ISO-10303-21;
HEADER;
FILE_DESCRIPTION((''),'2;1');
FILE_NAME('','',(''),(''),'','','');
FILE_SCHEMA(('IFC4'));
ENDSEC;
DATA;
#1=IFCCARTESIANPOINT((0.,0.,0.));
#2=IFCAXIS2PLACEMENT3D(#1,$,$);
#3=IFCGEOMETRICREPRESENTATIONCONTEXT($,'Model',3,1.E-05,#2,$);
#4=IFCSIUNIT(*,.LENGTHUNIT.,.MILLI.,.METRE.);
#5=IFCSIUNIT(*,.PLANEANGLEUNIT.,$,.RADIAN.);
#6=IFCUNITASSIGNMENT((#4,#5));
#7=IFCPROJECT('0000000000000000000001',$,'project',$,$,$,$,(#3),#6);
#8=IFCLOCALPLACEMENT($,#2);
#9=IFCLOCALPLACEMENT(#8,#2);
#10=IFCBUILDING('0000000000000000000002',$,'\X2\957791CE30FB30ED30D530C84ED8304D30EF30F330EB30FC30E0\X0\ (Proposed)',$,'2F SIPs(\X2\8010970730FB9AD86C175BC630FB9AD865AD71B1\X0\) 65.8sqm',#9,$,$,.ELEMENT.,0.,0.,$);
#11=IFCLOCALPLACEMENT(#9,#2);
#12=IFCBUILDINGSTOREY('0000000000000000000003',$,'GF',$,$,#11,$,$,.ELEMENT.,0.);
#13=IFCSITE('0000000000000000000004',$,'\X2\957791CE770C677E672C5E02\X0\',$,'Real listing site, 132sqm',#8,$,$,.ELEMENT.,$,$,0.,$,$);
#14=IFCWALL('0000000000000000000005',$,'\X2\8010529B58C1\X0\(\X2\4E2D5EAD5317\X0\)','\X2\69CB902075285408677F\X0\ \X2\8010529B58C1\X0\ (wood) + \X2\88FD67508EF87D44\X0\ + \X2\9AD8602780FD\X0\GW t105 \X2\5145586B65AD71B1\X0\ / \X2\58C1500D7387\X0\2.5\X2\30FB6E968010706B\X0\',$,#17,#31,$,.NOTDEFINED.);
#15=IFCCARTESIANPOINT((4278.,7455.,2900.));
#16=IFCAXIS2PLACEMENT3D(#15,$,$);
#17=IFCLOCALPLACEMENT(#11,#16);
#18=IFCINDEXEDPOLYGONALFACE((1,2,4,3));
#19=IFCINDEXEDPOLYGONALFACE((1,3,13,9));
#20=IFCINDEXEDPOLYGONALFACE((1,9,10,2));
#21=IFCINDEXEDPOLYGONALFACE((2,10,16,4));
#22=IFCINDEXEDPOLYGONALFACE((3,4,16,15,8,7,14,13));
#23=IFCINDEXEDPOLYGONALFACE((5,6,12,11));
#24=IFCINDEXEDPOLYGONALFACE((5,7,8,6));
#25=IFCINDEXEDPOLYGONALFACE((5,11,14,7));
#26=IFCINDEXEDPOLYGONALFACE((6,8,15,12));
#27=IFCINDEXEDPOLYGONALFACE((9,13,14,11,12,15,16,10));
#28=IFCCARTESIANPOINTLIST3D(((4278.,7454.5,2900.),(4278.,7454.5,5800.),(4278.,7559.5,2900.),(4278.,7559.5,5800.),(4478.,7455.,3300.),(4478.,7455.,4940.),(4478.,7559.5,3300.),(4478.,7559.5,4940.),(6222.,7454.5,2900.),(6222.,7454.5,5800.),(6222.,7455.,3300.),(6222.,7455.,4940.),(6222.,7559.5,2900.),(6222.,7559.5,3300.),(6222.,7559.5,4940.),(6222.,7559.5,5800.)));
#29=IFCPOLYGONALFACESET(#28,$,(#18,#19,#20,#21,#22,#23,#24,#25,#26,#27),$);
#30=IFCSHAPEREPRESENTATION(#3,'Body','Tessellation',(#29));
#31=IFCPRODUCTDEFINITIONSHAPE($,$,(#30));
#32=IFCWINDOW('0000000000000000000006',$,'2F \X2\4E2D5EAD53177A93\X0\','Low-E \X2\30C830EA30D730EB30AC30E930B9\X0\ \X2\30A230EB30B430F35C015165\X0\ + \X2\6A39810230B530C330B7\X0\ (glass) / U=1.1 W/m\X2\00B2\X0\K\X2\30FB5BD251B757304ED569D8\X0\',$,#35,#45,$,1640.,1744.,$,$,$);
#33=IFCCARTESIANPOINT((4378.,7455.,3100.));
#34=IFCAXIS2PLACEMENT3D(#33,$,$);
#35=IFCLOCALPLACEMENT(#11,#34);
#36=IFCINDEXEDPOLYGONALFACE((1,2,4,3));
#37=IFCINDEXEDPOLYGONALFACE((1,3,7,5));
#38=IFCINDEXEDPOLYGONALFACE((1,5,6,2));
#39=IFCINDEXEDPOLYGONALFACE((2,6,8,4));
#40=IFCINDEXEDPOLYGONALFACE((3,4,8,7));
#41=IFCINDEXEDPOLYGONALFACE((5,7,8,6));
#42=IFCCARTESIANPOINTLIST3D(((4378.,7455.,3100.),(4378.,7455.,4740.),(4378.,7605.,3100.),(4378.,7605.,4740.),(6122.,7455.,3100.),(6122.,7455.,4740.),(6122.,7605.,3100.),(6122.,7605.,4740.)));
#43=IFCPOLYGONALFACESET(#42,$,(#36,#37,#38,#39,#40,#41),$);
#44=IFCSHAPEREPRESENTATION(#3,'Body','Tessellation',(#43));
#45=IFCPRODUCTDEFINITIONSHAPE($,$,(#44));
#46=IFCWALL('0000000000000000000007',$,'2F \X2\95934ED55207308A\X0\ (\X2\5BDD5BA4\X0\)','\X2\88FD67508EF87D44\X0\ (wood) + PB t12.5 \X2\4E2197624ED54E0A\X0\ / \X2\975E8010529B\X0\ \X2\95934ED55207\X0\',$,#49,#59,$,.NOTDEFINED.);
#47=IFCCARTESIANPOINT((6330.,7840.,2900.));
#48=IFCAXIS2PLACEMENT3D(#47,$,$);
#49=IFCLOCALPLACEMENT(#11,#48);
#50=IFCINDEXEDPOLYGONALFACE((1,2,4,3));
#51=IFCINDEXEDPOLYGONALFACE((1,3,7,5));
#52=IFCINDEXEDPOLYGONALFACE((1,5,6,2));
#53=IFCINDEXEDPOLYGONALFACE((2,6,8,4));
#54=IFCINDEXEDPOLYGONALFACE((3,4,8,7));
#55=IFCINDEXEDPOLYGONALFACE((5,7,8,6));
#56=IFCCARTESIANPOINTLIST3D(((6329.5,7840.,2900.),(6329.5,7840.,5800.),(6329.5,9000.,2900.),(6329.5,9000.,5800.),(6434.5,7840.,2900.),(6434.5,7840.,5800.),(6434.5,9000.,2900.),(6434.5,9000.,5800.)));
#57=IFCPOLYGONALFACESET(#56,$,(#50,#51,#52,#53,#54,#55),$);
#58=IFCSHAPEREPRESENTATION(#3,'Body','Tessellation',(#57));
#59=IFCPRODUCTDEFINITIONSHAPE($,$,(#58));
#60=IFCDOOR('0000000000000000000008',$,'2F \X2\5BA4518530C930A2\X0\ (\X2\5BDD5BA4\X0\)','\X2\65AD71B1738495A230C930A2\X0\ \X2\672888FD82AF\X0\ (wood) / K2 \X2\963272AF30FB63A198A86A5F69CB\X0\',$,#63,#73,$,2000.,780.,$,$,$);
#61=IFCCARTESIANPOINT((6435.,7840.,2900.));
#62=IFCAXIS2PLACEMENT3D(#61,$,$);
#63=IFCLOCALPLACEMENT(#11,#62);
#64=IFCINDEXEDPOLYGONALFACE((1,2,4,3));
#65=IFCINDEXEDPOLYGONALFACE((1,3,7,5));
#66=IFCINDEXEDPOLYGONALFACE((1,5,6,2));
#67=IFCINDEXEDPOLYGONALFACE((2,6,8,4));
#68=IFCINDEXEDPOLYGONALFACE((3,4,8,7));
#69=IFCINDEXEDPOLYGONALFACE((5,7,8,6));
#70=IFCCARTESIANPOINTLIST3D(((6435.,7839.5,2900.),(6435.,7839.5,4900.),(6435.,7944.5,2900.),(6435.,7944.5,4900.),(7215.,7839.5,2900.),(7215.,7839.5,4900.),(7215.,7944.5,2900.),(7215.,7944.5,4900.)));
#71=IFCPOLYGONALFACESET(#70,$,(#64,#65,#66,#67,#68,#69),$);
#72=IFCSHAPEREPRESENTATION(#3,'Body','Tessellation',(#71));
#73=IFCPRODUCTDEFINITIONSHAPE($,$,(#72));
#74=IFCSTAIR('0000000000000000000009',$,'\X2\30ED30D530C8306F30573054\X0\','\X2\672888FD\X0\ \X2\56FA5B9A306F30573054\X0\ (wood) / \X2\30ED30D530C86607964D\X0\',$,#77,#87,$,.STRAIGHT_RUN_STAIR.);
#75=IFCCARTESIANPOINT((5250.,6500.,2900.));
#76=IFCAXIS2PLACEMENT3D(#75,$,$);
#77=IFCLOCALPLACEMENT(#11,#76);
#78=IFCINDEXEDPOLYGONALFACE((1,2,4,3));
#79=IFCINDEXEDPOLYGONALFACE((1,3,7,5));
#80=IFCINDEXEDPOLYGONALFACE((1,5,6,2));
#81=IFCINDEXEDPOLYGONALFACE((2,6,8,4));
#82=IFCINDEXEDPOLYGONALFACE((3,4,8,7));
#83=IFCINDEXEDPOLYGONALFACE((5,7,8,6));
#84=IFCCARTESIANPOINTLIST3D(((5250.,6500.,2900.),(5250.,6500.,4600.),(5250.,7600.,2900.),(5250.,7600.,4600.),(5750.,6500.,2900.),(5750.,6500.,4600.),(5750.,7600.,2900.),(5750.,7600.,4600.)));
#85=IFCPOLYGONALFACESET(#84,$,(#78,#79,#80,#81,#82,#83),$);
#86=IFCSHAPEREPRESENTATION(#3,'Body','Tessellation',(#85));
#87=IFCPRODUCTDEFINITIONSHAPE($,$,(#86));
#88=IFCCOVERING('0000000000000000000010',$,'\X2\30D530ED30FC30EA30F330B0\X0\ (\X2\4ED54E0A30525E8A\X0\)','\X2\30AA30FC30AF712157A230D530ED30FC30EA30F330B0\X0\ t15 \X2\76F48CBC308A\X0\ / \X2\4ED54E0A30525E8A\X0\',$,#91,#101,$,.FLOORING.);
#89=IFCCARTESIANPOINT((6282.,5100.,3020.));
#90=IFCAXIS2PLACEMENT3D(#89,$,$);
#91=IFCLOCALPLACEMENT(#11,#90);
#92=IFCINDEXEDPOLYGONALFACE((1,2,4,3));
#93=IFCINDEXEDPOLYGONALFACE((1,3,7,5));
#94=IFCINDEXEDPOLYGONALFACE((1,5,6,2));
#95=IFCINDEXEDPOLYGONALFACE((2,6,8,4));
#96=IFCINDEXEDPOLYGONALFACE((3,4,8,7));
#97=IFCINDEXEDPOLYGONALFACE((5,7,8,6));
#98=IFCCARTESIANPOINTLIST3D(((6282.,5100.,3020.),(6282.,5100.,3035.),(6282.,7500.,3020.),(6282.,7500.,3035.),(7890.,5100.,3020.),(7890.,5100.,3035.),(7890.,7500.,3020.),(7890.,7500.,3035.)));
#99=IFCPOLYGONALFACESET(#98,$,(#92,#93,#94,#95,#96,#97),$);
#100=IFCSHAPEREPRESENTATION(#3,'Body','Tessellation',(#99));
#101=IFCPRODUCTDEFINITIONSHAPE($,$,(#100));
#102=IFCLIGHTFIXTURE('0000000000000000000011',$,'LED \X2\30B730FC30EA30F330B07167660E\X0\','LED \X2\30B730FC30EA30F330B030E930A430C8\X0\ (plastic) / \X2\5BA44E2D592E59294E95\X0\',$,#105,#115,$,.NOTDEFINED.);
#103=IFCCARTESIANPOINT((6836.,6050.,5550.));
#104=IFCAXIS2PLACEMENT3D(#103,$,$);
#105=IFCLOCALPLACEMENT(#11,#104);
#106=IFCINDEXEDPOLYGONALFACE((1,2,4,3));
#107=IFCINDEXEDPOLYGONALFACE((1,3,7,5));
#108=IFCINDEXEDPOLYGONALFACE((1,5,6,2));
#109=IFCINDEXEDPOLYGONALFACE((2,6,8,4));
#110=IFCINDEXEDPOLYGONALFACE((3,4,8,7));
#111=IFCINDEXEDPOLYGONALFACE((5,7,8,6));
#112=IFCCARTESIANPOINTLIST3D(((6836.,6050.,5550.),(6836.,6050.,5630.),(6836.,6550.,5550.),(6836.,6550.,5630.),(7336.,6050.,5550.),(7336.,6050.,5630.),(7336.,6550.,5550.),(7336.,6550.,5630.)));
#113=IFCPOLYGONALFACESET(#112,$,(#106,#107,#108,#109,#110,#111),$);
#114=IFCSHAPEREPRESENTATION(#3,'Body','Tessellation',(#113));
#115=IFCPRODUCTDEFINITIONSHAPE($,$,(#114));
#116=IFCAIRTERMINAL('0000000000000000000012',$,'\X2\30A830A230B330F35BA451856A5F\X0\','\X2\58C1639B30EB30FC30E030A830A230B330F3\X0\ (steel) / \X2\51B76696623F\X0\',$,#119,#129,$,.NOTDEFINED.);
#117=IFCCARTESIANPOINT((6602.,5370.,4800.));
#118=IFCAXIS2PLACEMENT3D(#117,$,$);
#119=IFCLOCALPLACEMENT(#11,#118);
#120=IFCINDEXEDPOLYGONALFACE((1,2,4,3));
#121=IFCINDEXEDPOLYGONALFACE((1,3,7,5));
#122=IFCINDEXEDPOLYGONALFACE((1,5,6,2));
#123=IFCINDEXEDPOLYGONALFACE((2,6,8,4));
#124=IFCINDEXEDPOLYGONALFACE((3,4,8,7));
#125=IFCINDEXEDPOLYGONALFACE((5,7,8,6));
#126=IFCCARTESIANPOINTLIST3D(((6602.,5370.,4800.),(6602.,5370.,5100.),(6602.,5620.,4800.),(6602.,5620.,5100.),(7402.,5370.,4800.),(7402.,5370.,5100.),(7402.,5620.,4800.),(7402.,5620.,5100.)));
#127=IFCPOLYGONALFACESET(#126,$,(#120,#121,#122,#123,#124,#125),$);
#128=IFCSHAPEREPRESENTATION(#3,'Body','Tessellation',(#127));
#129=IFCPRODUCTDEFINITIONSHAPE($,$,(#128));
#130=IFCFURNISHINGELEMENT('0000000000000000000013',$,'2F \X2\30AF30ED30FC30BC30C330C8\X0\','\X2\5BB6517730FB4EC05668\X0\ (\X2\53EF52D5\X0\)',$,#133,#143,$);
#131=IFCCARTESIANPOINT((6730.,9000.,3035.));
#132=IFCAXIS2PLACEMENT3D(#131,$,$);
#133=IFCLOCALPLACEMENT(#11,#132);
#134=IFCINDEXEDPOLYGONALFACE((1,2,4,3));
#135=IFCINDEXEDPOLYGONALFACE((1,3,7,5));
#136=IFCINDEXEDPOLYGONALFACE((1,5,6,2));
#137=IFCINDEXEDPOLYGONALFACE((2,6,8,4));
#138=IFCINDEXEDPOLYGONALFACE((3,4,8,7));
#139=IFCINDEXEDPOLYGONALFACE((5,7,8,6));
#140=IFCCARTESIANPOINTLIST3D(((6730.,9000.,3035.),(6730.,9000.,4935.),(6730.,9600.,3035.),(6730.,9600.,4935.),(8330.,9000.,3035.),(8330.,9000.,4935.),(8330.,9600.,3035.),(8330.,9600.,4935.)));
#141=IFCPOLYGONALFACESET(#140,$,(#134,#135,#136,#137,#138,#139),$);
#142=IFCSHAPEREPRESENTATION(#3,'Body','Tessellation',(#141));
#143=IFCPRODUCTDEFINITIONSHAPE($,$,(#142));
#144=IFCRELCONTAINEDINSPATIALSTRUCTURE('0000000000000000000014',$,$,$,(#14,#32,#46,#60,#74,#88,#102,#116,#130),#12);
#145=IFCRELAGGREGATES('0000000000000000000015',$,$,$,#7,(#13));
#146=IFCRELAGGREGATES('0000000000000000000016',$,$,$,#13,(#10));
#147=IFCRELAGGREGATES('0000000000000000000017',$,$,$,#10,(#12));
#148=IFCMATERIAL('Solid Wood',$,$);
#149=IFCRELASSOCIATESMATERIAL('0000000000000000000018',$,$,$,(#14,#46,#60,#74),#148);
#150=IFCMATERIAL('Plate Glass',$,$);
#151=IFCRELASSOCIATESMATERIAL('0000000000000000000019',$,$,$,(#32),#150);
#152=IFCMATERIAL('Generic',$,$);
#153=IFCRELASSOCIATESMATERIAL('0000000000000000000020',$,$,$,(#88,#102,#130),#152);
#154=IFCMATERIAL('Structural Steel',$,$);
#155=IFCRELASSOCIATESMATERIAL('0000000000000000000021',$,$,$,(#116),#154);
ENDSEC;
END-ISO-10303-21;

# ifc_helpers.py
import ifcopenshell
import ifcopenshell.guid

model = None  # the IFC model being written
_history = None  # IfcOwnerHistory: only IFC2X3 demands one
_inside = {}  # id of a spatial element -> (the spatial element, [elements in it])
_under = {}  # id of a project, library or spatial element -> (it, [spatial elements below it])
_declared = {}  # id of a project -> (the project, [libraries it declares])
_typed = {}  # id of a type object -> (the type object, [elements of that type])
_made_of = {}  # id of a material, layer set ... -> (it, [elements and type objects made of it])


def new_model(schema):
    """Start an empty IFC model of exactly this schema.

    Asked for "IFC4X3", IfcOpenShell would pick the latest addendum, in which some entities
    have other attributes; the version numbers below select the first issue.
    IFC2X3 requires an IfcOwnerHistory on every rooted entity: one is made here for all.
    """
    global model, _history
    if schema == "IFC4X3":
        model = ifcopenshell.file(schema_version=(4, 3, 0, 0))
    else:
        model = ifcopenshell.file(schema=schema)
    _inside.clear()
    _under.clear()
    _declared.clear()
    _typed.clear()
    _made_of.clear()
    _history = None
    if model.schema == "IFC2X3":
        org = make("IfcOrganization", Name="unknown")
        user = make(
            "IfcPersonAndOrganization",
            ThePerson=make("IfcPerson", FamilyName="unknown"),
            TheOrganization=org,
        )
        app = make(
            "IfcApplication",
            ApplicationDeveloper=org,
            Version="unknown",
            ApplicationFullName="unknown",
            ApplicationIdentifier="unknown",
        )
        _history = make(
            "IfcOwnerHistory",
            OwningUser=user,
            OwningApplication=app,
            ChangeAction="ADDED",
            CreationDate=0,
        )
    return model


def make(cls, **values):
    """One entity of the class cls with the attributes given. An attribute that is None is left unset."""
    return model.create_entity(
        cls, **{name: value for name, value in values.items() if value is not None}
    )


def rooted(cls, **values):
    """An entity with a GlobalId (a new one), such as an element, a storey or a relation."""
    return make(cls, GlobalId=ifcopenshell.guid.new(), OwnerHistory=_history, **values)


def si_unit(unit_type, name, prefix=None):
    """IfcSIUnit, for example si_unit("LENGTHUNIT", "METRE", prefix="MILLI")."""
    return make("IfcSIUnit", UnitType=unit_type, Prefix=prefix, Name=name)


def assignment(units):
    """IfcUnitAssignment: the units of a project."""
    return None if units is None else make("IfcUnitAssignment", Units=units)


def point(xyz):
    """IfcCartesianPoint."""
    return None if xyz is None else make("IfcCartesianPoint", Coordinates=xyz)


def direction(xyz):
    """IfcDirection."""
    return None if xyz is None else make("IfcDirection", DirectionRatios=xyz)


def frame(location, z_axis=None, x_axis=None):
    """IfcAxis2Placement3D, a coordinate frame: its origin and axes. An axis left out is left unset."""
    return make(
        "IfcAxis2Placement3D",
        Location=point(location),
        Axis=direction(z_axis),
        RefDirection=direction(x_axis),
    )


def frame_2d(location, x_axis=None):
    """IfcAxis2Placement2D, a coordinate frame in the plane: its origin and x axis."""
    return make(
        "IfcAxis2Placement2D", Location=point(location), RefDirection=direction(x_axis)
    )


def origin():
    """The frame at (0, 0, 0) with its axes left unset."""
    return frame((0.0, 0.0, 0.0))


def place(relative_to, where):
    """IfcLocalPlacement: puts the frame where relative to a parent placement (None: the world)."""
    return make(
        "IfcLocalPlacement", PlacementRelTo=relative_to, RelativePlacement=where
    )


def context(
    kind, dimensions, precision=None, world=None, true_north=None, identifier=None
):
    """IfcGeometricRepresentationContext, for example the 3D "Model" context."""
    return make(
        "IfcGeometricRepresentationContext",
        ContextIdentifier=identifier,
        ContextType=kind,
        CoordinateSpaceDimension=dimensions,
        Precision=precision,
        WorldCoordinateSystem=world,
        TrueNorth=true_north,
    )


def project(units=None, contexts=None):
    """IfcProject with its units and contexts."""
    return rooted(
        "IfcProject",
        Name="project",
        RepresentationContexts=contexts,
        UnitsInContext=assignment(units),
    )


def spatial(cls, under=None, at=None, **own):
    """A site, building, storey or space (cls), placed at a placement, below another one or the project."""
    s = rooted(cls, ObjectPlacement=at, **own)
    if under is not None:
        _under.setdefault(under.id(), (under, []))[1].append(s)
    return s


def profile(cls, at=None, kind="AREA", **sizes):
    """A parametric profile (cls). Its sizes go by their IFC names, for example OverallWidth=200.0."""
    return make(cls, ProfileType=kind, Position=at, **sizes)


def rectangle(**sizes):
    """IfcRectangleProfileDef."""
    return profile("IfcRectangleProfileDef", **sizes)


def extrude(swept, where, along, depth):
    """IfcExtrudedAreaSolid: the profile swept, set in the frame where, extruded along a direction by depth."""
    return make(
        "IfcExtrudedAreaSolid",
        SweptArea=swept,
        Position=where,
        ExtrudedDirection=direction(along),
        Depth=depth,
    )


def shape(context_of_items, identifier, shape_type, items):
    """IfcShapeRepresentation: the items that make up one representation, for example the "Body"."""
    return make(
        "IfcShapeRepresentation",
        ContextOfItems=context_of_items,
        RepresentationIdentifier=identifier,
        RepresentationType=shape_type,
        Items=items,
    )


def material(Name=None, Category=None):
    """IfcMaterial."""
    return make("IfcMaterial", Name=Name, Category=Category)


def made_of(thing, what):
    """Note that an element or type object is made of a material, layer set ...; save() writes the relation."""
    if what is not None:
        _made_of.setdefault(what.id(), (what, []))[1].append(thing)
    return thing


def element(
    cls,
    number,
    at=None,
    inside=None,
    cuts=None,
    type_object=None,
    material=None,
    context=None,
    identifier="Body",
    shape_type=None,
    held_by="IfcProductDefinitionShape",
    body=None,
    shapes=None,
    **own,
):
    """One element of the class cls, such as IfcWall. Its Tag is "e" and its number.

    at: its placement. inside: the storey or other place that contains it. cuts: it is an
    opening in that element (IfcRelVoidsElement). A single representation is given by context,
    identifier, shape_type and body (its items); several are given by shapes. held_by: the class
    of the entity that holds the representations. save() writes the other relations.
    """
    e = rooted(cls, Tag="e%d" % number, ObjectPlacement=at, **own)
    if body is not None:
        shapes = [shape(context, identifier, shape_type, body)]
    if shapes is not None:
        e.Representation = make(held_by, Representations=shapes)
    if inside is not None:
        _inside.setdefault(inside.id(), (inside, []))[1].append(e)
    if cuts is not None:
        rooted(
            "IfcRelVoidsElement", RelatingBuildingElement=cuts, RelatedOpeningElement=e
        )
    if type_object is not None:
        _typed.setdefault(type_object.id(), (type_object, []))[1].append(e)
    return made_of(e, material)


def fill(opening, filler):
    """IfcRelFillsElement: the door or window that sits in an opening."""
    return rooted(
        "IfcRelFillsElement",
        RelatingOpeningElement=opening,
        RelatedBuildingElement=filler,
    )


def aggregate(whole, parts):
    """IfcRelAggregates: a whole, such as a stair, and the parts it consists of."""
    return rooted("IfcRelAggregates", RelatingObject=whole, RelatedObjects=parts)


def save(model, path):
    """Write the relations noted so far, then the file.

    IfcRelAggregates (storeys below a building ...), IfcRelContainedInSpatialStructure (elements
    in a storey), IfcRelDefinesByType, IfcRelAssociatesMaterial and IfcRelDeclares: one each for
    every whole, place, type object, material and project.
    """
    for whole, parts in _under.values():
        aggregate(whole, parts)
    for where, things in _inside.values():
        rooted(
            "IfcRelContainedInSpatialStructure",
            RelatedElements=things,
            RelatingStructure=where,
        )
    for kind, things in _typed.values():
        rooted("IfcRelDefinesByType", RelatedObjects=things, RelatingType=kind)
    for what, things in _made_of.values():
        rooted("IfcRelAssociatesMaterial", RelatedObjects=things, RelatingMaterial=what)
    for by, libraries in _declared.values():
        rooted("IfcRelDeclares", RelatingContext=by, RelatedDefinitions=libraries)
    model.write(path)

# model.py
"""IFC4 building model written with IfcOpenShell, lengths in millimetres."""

from ifc_helpers import new_model, si_unit, frame, frame_2d, origin, place, context, project, spatial, rectangle, extrude, material, element, fill, save


model = new_model("IFC4")

# Units and contexts
model_context = context("Model", 3, precision=1e-05, world=origin())
ifc_project = project(units=[si_unit("LENGTHUNIT", "METRE", prefix="MILLI"), si_unit("PLANEANGLEUNIT", "RADIAN")], contexts=[model_context])

# Site, building, storey
site_placement = place(None, origin())
site = spatial("IfcSite", under=ifc_project, at=site_placement, Name="長野県松本市", ObjectType="Real listing site, 132sqm", CompositionType="ELEMENT", RefElevation=0.0)
building_placement = place(site_placement, origin())
building = spatial("IfcBuilding", under=site, at=building_placement, Name="長野・ロフト付きワンルーム (Proposed)", ObjectType="2F SIPs(耐震・高気密・高断熱) 65.8sqm", CompositionType="ELEMENT", ElevationOfRefHeight=0.0, ElevationOfTerrain=0.0)
storey_placement = place(building_placement, origin())
storey = spatial("IfcBuildingStorey", under=building, at=storey_placement, Name="GF", CompositionType="ELEMENT", Elevation=0.0)

# Shared definitions
ifc_material_1 = material(Name="Solid Wood")

# Wall, opening, window
wall_1_placement = place(storey_placement, frame((4278.0, 7455.0, 2900.0)))
wall_1 = element("IfcWall", 1, at=wall_1_placement, inside=storey, material=ifc_material_1, Name="耐力壁(中庭北)", Description="構造用合板 耐力壁 (wood) + 製材軸組 + 高性能GW t105 充填断熱 / 壁倍率2.5・準耐火", PredefinedType="NOTDEFINED", context=model_context, shape_type="SweptSolid", body=[
    extrude(rectangle(XDim=1944.0, YDim=105.0, at=frame_2d((972.0, 52.0))), frame((4278.0, 7455.0, 2900.0)), (0.0, 0.0, 1.0), 2900.0),
])
opening_placement = place(storey_placement, frame((4378.0, 7455.0, 3100.0)))
opening = element("IfcOpeningElement", 2, at=opening_placement, cuts=wall_1, PredefinedType="NOTDEFINED", context=model_context, shape_type="SweptSolid", body=[
    extrude(rectangle(XDim=1744.0, YDim=150.0, at=frame_2d((872.0, 75.0))), frame((4378.0, 7455.0, 3100.0)), (0.0, 0.0, 1.0), 1640.0),
])
ifc_material_2 = material(Name="Plate Glass")
window_placement = place(storey_placement, frame((4378.0, 7455.0, 3100.0)))
window = element("IfcWindow", 3, at=window_placement, inside=storey, material=ifc_material_2, Name="2F 中庭北窓", Description="Low-E トリプルガラス アルゴン封入 + 樹脂サッシ (glass) / U=1.1 W/m²K・寒冷地仕様", OverallHeight=1640.0, OverallWidth=1744.0, context=model_context, shape_type="SweptSolid", body=[
    extrude(rectangle(XDim=1744.0, YDim=150.0, at=frame_2d((872.0, 75.0))), frame((4378.0, 7455.0, 3100.0)), (0.0, 0.0, 1.0), 1640.0),
])
fill(opening, window)

# Wall
wall_2_placement = place(storey_placement, frame((6330.0, 7840.0, 2900.0)))
element("IfcWall", 4, at=wall_2_placement, inside=storey, material=ifc_material_1, Name="2F 間仕切り (寝室)", Description="製材軸組 (wood) + PB t12.5 両面仕上 / 非耐力 間仕切", PredefinedType="NOTDEFINED", context=model_context, shape_type="SweptSolid", body=[
    extrude(rectangle(XDim=105.0, YDim=1160.0, at=frame_2d((52.0, 580.0))), frame((6330.0, 7840.0, 2900.0)), (0.0, 0.0, 1.0), 2900.0),
])

# Door
door_placement = place(storey_placement, frame((6435.0, 7840.0, 2900.0)))
element("IfcDoor", 5, at=door_placement, inside=storey, material=ifc_material_1, Name="2F 室内ドア (寝室)", Description="断熱玄関ドア 木製芯 (wood) / K2 防犯・採風機構", OverallHeight=2000.0, OverallWidth=780.0, context=model_context, shape_type="SweptSolid", body=[
    extrude(rectangle(XDim=780.0, YDim=105.0, at=frame_2d((390.0, 52.0))), frame((6435.0, 7840.0, 2900.0)), (0.0, 0.0, 1.0), 2000.0),
])

# Stair
stair_placement = place(storey_placement, frame((5250.0, 6500.0, 2900.0)))
element("IfcStair", 6, at=stair_placement, inside=storey, material=ifc_material_1, Name="ロフトはしご", Description="木製 固定はしご (wood) / ロフト昇降", PredefinedType="STRAIGHT_RUN_STAIR", context=model_context, shape_type="SweptSolid", body=[
    extrude(rectangle(XDim=500.0, YDim=1100.0, at=frame_2d((250.0, 550.0))), frame((5250.0, 6500.0, 2900.0)), (0.0, 0.0, 1.0), 1700.0),
])

# Covering
ifc_material_3 = material(Name="Generic")
covering_placement = place(storey_placement, frame((6282.0, 5100.0, 3020.0)))
element("IfcCovering", 7, at=covering_placement, inside=storey, material=ifc_material_3, Name="フローリング (仕上げ床)", Description="オーク無垢フローリング t15 直貼り / 仕上げ床", PredefinedType="FLOORING", context=model_context, shape_type="SweptSolid", body=[
    extrude(rectangle(XDim=1608.0, YDim=2400.0, at=frame_2d((804.0, 1200.0))), frame((6282.0, 5100.0, 3020.0)), (0.0, 0.0, 1.0), 15.0),
])

# Light fixture
light_fixture_placement = place(storey_placement, frame((6836.0, 6050.0, 5550.0)))
element("IfcLightFixture", 8, at=light_fixture_placement, inside=storey, material=ifc_material_3, Name="LED シーリング照明", Description="LED シーリングライト (plastic) / 室中央天井", PredefinedType="NOTDEFINED", context=model_context, shape_type="SweptSolid", body=[
    extrude(rectangle(XDim=500.0, YDim=500.0, at=frame_2d((250.0, 250.0))), frame((6836.0, 6050.0, 5550.0)), (0.0, 0.0, 1.0), 80.0),
])

# Air terminal
ifc_material_4 = material(Name="Structural Steel")
air_terminal_placement = place(storey_placement, frame((6602.0, 5370.0, 4800.0)))
element("IfcAirTerminal", 9, at=air_terminal_placement, inside=storey, material=ifc_material_4, Name="エアコン室内機", Description="壁掛ルームエアコン (steel) / 冷暖房", PredefinedType="NOTDEFINED", context=model_context, shape_type="SweptSolid", body=[
    extrude(rectangle(XDim=800.0, YDim=250.0, at=frame_2d((400.0, 125.0))), frame((6602.0, 5370.0, 4800.0)), (0.0, 0.0, 1.0), 300.0),
])

# Furnishing element
furnishing_placement = place(storey_placement, frame((6730.0, 9000.0, 3035.0)))
element("IfcFurnishingElement", 10, at=furnishing_placement, inside=storey, material=ifc_material_3, Name="2F クローゼット", Description="家具・什器 (可動)", context=model_context, shape_type="SweptSolid", body=[
    extrude(rectangle(XDim=1600.0, YDim=600.0, at=frame_2d((800.0, 300.0))), frame((6730.0, 9000.0, 3035.0)), (0.0, 0.0, 1.0), 1900.0),
])

save(model, "model.ifc")
